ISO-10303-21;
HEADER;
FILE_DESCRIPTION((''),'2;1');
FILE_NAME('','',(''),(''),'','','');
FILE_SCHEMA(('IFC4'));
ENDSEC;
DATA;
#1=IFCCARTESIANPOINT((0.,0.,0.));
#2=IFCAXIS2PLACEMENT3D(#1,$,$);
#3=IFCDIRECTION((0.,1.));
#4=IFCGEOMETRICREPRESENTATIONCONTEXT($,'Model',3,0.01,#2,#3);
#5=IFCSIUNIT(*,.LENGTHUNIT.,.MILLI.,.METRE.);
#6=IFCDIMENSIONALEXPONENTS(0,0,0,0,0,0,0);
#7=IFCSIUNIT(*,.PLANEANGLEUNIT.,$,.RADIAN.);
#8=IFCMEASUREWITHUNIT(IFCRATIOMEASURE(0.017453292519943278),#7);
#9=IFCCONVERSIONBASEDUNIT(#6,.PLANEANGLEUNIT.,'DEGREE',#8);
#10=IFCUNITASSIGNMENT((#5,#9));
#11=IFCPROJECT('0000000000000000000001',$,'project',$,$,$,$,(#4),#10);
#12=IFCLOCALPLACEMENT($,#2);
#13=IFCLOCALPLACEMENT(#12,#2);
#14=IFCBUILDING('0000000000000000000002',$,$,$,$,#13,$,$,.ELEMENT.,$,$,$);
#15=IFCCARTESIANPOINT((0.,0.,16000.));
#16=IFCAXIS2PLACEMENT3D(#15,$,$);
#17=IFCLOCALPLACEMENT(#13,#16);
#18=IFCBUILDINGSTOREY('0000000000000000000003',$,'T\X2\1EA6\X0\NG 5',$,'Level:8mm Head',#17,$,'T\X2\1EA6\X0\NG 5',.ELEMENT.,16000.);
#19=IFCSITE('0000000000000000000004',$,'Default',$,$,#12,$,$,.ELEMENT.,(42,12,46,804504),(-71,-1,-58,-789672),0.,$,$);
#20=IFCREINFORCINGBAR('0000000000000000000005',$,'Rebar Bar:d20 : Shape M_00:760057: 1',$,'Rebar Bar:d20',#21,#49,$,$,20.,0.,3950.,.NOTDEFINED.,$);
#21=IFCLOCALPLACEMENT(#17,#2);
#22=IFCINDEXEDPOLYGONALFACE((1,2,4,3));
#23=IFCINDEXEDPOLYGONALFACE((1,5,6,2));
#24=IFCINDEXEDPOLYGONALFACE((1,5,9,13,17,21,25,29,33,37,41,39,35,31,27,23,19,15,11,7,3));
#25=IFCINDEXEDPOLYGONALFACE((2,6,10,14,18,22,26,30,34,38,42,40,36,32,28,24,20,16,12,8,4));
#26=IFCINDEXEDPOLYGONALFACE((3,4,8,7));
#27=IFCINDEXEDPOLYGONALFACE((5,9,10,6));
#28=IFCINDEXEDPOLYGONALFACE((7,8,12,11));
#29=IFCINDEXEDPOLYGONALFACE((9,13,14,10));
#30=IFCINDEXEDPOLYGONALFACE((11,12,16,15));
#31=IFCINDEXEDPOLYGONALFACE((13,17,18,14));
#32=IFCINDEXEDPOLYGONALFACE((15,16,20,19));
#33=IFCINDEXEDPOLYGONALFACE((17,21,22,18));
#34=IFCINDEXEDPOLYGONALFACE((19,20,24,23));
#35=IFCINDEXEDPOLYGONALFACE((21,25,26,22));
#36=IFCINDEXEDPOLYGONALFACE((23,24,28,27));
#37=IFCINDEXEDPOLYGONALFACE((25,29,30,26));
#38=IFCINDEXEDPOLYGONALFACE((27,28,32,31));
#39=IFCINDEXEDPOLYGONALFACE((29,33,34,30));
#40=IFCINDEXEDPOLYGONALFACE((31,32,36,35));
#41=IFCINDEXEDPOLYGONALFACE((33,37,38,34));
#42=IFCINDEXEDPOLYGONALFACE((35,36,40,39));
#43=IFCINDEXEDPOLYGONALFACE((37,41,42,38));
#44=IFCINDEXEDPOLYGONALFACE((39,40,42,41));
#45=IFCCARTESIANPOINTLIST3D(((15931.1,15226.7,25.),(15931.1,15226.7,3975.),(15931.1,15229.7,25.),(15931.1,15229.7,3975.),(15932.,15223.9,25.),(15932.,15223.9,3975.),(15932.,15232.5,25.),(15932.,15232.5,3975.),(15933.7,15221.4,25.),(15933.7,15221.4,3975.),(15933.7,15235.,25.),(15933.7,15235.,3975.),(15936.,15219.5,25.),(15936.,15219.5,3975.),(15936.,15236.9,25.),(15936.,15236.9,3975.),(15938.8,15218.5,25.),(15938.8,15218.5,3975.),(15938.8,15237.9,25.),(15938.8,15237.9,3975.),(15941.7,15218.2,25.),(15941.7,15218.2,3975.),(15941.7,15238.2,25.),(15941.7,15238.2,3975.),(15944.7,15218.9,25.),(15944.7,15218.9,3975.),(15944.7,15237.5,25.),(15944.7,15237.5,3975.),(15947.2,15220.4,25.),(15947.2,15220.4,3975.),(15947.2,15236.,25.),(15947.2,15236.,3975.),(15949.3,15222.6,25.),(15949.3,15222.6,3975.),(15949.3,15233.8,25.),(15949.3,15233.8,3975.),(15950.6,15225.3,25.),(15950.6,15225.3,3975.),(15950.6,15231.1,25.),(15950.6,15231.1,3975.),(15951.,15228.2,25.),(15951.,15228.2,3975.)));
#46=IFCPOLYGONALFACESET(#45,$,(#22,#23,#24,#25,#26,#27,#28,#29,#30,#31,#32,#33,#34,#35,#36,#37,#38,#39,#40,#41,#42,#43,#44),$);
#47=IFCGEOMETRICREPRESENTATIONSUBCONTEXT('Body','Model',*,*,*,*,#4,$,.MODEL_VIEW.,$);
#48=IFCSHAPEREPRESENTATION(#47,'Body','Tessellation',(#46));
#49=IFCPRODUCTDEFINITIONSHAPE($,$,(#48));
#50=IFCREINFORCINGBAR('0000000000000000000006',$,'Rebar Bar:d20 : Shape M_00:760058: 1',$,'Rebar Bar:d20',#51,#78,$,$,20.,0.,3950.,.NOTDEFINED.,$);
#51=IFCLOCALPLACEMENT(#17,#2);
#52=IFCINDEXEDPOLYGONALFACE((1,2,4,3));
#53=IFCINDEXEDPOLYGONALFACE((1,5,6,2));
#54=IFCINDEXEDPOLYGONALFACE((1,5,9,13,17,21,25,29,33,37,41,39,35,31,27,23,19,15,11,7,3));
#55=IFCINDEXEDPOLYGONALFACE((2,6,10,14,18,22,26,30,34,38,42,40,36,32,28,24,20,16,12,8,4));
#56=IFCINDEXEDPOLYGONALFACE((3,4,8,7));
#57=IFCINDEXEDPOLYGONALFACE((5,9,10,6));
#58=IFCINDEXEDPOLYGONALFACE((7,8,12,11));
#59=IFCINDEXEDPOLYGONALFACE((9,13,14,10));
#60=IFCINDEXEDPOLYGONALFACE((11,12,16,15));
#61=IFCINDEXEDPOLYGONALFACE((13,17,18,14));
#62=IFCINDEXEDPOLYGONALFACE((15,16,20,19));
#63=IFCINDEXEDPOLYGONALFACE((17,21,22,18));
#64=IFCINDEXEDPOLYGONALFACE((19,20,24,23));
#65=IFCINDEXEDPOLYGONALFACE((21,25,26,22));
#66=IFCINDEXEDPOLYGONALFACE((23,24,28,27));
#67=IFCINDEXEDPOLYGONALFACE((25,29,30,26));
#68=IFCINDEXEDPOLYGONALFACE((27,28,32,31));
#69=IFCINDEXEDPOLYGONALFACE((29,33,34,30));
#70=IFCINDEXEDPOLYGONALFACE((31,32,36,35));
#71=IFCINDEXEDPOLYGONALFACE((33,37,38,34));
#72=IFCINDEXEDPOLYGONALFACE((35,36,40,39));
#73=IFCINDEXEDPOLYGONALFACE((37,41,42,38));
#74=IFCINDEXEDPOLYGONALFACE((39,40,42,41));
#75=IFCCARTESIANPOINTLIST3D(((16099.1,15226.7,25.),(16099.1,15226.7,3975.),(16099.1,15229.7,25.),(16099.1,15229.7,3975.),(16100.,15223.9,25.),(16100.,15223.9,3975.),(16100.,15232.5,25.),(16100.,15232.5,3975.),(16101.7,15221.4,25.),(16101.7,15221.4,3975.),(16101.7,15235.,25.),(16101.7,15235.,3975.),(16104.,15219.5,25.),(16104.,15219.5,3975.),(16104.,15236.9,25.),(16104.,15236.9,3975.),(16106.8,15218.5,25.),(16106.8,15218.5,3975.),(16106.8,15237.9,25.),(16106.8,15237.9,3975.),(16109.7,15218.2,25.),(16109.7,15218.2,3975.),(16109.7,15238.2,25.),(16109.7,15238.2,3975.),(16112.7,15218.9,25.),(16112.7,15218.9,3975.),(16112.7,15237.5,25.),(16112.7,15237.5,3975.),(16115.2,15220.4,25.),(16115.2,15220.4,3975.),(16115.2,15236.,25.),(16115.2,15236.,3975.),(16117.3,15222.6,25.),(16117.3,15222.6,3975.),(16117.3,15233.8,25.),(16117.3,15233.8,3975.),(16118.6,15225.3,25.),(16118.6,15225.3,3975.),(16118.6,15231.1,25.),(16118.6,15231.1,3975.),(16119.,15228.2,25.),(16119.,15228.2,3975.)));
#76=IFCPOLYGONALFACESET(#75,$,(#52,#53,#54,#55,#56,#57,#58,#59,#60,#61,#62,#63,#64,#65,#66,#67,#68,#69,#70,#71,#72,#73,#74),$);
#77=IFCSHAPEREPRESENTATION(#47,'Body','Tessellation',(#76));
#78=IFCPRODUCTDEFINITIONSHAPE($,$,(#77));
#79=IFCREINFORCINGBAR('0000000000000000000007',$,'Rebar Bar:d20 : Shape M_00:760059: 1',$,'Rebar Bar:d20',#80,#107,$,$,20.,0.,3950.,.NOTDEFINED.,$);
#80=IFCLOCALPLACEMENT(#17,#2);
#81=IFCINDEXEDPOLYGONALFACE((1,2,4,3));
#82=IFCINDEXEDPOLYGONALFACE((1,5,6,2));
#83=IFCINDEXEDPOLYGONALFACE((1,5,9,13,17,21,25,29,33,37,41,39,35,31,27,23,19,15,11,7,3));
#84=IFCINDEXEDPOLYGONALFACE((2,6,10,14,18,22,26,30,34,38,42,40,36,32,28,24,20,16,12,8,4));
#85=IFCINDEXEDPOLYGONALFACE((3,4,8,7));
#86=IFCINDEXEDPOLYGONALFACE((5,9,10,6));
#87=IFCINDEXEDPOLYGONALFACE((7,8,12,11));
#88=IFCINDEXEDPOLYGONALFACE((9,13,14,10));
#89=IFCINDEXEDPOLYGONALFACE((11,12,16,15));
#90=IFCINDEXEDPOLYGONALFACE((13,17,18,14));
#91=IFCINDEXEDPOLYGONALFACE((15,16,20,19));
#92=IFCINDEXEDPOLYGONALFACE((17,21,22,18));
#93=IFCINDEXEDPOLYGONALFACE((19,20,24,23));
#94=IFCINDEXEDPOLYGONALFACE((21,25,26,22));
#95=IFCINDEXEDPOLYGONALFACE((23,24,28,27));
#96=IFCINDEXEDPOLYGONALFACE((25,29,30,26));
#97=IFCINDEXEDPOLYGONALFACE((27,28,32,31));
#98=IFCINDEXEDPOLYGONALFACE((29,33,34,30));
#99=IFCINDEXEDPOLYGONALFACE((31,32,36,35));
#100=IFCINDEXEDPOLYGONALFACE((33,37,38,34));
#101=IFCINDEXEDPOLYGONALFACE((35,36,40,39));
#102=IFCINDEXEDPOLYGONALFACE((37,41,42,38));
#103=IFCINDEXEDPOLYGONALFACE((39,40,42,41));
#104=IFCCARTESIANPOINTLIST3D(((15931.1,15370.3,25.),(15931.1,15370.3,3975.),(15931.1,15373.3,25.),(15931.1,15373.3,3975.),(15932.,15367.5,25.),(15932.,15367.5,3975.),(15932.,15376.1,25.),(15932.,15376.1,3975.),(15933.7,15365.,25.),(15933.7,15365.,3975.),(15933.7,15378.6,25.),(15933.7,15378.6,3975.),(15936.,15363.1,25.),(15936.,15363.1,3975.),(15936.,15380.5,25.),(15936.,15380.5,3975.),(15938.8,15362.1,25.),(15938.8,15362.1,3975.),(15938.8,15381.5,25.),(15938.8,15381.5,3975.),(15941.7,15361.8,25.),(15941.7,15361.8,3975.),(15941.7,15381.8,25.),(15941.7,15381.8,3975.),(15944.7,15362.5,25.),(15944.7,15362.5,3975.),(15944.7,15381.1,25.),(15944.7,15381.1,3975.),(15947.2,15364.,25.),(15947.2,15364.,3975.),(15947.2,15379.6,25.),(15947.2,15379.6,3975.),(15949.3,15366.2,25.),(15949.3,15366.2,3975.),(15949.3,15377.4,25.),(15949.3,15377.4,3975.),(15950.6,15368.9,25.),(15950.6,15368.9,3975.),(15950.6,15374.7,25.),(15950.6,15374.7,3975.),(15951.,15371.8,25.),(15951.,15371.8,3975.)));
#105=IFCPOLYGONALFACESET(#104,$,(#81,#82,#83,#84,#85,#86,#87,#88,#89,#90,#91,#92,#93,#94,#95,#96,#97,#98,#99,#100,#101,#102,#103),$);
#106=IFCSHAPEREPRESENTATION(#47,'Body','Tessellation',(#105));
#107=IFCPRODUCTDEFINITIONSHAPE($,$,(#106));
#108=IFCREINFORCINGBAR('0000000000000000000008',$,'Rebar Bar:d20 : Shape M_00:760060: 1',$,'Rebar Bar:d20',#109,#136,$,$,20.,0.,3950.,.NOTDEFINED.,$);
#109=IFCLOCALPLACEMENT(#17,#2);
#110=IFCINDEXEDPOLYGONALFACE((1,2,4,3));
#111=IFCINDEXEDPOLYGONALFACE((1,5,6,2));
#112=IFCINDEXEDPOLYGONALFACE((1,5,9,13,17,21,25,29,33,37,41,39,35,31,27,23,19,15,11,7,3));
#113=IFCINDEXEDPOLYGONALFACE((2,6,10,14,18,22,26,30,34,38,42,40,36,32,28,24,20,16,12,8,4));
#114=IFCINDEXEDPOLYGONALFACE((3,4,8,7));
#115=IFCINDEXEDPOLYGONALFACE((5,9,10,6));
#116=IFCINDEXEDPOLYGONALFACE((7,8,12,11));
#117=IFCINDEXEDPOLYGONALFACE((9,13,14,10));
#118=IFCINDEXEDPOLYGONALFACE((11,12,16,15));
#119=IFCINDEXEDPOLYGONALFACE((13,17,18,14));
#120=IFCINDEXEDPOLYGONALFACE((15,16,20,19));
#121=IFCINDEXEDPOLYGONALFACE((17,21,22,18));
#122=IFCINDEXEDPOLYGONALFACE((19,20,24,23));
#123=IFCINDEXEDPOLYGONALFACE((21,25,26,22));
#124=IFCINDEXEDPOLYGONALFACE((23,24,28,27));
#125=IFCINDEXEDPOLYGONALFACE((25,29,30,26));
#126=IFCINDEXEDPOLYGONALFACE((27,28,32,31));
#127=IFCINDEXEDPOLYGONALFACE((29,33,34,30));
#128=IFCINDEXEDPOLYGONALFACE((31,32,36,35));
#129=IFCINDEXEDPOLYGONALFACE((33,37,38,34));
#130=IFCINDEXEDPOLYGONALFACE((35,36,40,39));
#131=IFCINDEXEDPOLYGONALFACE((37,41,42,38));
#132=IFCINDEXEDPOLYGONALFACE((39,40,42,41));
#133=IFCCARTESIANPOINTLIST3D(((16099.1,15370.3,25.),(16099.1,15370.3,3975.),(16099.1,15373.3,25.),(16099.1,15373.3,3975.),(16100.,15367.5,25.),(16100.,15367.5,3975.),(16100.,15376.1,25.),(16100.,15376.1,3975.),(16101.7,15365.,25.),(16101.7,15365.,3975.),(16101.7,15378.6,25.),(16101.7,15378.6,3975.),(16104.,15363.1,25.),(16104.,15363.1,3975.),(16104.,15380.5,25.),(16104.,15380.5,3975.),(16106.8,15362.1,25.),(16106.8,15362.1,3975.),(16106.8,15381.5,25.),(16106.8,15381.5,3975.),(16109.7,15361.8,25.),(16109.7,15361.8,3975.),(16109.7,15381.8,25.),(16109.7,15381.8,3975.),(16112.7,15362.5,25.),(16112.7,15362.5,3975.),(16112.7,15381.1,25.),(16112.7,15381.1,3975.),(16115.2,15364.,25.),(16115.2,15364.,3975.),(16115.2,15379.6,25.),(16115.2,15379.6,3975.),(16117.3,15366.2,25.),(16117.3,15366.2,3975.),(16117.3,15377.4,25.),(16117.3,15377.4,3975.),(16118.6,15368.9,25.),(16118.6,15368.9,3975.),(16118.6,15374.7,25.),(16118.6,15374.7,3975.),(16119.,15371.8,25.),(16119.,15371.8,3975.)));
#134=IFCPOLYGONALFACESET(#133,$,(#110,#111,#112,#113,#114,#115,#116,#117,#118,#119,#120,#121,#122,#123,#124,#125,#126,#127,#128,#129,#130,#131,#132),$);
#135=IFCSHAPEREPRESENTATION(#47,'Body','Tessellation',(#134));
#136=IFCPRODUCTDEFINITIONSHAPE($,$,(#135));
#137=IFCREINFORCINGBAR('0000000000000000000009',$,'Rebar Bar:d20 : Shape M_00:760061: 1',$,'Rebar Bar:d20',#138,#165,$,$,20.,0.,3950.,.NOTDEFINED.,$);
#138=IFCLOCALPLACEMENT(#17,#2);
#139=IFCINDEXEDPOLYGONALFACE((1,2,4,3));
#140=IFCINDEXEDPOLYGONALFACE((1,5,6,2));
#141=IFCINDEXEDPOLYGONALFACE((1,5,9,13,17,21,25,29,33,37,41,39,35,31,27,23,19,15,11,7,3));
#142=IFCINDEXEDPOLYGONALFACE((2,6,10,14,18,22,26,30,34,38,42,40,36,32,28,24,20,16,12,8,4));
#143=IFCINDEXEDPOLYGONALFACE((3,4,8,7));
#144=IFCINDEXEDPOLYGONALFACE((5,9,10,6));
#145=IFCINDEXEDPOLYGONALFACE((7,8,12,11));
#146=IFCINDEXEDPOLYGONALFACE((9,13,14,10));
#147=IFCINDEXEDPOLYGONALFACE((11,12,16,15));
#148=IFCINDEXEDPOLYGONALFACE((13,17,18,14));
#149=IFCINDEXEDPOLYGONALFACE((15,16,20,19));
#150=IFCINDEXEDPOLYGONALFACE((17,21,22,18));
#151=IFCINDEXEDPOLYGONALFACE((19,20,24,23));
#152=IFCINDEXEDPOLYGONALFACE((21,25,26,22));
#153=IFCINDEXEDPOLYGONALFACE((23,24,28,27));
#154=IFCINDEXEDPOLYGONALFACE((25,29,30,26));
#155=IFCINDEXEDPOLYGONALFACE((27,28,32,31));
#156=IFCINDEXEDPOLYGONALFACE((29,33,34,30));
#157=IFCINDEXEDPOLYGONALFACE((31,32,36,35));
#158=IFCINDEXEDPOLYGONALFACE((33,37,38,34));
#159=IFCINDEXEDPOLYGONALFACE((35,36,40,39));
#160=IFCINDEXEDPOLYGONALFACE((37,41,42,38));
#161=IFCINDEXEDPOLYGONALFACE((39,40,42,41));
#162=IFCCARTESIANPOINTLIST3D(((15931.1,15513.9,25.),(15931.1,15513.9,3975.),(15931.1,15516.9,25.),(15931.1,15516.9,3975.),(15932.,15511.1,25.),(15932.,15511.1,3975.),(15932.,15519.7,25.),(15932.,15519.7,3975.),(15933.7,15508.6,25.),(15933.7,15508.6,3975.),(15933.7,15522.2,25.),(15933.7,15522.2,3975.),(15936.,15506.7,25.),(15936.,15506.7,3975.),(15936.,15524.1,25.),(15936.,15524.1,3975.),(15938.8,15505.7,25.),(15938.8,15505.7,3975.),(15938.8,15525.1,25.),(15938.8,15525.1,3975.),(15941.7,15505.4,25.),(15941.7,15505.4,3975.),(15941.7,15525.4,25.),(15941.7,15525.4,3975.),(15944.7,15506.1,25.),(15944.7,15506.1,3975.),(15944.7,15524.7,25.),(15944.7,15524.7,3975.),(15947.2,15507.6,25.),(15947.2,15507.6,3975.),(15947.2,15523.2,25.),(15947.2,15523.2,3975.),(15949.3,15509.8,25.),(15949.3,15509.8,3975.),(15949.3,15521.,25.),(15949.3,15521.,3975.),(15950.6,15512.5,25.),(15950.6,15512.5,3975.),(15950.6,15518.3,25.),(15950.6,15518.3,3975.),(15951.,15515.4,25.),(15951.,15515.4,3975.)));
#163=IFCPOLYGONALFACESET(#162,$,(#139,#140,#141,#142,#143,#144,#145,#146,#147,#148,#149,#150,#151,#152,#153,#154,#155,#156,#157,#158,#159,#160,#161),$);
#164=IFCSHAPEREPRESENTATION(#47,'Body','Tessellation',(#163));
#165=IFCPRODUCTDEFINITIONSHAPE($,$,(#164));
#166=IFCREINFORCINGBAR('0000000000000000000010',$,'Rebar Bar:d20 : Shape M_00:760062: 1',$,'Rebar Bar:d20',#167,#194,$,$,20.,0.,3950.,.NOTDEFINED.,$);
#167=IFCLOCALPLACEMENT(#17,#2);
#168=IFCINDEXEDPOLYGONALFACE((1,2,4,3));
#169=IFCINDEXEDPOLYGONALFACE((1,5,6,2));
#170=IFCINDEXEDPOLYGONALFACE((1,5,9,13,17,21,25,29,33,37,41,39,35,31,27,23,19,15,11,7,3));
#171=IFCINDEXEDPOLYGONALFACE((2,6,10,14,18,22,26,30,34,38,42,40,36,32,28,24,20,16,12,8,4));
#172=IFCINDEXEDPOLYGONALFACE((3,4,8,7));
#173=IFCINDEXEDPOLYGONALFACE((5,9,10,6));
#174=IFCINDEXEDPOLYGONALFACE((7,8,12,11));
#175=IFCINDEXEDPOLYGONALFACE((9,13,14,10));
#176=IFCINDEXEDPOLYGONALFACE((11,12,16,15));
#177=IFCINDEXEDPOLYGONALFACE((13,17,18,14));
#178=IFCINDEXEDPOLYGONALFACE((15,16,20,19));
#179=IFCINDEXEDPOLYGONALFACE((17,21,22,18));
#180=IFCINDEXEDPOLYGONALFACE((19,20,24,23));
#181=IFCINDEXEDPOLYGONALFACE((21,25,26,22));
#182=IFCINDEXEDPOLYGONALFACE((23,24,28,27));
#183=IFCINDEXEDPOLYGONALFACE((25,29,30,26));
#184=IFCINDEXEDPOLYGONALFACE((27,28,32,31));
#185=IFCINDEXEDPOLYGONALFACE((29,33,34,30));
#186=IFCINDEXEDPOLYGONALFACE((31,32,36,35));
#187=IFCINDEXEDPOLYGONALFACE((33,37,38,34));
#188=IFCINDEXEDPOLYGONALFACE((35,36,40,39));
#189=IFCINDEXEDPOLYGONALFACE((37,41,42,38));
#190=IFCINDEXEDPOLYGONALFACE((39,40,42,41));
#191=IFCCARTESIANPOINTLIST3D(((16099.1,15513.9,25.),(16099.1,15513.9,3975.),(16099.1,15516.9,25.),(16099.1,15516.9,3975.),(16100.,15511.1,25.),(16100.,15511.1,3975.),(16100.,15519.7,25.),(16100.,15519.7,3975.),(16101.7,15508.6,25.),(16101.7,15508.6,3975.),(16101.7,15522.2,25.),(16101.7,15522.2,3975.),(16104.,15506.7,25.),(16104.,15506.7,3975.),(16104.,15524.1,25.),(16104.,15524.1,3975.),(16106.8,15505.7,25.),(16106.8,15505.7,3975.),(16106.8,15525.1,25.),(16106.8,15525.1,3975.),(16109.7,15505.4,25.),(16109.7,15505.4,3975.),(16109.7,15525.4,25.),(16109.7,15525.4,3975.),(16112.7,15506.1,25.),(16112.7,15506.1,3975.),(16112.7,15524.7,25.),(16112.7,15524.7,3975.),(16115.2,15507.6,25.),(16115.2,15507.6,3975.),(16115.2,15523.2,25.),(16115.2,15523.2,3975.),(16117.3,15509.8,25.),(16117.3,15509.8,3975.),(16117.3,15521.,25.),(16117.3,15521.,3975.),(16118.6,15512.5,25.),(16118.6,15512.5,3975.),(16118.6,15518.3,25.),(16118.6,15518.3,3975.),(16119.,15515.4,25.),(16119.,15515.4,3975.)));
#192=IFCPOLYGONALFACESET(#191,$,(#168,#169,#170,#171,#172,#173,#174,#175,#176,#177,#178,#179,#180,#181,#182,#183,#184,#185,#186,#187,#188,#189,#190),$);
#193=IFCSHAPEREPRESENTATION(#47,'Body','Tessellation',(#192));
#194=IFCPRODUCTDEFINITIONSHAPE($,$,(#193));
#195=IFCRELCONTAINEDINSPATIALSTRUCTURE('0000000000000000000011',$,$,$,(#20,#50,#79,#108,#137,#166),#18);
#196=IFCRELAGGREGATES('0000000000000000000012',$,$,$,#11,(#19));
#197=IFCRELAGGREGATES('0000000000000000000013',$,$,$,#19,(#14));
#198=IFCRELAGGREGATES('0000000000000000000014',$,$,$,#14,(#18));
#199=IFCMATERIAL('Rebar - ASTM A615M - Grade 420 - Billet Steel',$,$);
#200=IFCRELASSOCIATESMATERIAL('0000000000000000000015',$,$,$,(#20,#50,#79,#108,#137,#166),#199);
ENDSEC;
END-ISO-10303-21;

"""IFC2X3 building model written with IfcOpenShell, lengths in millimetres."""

from ifc_helpers import new_model, entity, si_unit, converted_unit, direction, frame, origin, place, context, subcontext, project, spatial, material, element, save


model = new_model("IFC2X3")

# Units and contexts
model_context = context("Model", 3, precision=0.01, world=origin(), true_north=direction((0.0, 1.0)))
body_context = subcontext(model_context, "Body", "Model", "MODEL_VIEW")
ifc_project = project(units=[si_unit("LENGTHUNIT", "METRE", prefix="MILLI"), converted_unit("PLANEANGLEUNIT", "DEGREE", entity("IfcRatioMeasure", 0.017453292519943278), si_unit("PLANEANGLEUNIT", "RADIAN"), dimensions=[0, 0, 0, 0, 0, 0, 0])], contexts=[model_context])

# Site, building, storey
site_placement = place(None, origin())
site = spatial("IfcSite", under=ifc_project, at=site_placement, Name="Default", CompositionType="ELEMENT", RefLatitude=(42, 12, 46, 804504), RefLongitude=(-71, -1, -58, -789672), RefElevation=0.0)
building_placement = place(site_placement, origin())
building = spatial("IfcBuilding", under=site, at=building_placement, CompositionType="ELEMENT")
storey_placement = place(building_placement, frame((0.0, 0.0, 16000.0)))
storey = spatial("IfcBuildingStorey", under=building, at=storey_placement, Name="TẦNG 5", ObjectType="Level:8mm Head", LongName="TẦNG 5", CompositionType="ELEMENT", Elevation=16000.0)

# Reinforcing bars
ifc_material = material(Name="Rebar - ASTM A615M - Grade 420 - Billet Steel")
reinforcing_bar_1_placement = place(storey_placement, origin())
element("IfcReinforcingBar", 1, at=reinforcing_bar_1_placement, inside=storey, material=ifc_material, Name="Rebar Bar:d20 : Shape M_00:760057: 1", ObjectType="Rebar Bar:d20", BarLength=3950.0, BarRole="NOTDEFINED", CrossSectionArea=0.0, NominalDiameter=20.0, context=body_context, shape_type="AdvancedSweptSolid", body=[
    entity("IfcSweptDiskSolid", entity("IfcCompositeCurve", [entity("IfcCompositeCurveSegment", "CONTINUOUS", True, entity("IfcPolyline", [entity("IfcCartesianPoint", [15941.0, 15228.2, 25.0]), entity("IfcCartesianPoint", [15941.0, 15228.2, 3975.0])]))], False), 10.0, None, 0.0, 1.0),
])
reinforcing_bar_2_placement = place(storey_placement, origin())
element("IfcReinforcingBar", 2, at=reinforcing_bar_2_placement, inside=storey, material=ifc_material, Name="Rebar Bar:d20 : Shape M_00:760058: 1", ObjectType="Rebar Bar:d20", BarLength=3950.0, BarRole="NOTDEFINED", CrossSectionArea=0.0, NominalDiameter=20.0, context=body_context, shape_type="AdvancedSweptSolid", body=[
    entity("IfcSweptDiskSolid", entity("IfcCompositeCurve", [entity("IfcCompositeCurveSegment", "CONTINUOUS", True, entity("IfcPolyline", [entity("IfcCartesianPoint", [16109.0, 15228.2, 25.0]), entity("IfcCartesianPoint", [16109.0, 15228.2, 3975.0])]))], False), 10.0, None, 0.0, 1.0),
])
reinforcing_bar_3_placement = place(storey_placement, origin())
element("IfcReinforcingBar", 3, at=reinforcing_bar_3_placement, inside=storey, material=ifc_material, Name="Rebar Bar:d20 : Shape M_00:760059: 1", ObjectType="Rebar Bar:d20", BarLength=3950.0, BarRole="NOTDEFINED", CrossSectionArea=0.0, NominalDiameter=20.0, context=body_context, shape_type="AdvancedSweptSolid", body=[
    entity("IfcSweptDiskSolid", entity("IfcCompositeCurve", [entity("IfcCompositeCurveSegment", "CONTINUOUS", True, entity("IfcPolyline", [entity("IfcCartesianPoint", [15941.0, 15371.8, 25.0]), entity("IfcCartesianPoint", [15941.0, 15371.8, 3975.0])]))], False), 10.0, None, 0.0, 1.0),
])
reinforcing_bar_4_placement = place(storey_placement, origin())
element("IfcReinforcingBar", 4, at=reinforcing_bar_4_placement, inside=storey, material=ifc_material, Name="Rebar Bar:d20 : Shape M_00:760060: 1", ObjectType="Rebar Bar:d20", BarLength=3950.0, BarRole="NOTDEFINED", CrossSectionArea=0.0, NominalDiameter=20.0, context=body_context, shape_type="AdvancedSweptSolid", body=[
    entity("IfcSweptDiskSolid", entity("IfcCompositeCurve", [entity("IfcCompositeCurveSegment", "CONTINUOUS", True, entity("IfcPolyline", [entity("IfcCartesianPoint", [16109.0, 15371.8, 25.0]), entity("IfcCartesianPoint", [16109.0, 15371.8, 3975.0])]))], False), 10.0, None, 0.0, 1.0),
])
reinforcing_bar_5_placement = place(storey_placement, origin())
element("IfcReinforcingBar", 5, at=reinforcing_bar_5_placement, inside=storey, material=ifc_material, Name="Rebar Bar:d20 : Shape M_00:760061: 1", ObjectType="Rebar Bar:d20", BarLength=3950.0, BarRole="NOTDEFINED", CrossSectionArea=0.0, NominalDiameter=20.0, context=body_context, shape_type="AdvancedSweptSolid", body=[
    entity("IfcSweptDiskSolid", entity("IfcCompositeCurve", [entity("IfcCompositeCurveSegment", "CONTINUOUS", True, entity("IfcPolyline", [entity("IfcCartesianPoint", [15941.0, 15515.4, 25.0]), entity("IfcCartesianPoint", [15941.0, 15515.4, 3975.0])]))], False), 10.0, None, 0.0, 1.0),
])
reinforcing_bar_6_placement = place(storey_placement, origin())
element("IfcReinforcingBar", 6, at=reinforcing_bar_6_placement, inside=storey, material=ifc_material, Name="Rebar Bar:d20 : Shape M_00:760062: 1", ObjectType="Rebar Bar:d20", BarLength=3950.0, BarRole="NOTDEFINED", CrossSectionArea=0.0, NominalDiameter=20.0, context=body_context, shape_type="AdvancedSweptSolid", body=[
    entity("IfcSweptDiskSolid", entity("IfcCompositeCurve", [entity("IfcCompositeCurveSegment", "CONTINUOUS", True, entity("IfcPolyline", [entity("IfcCartesianPoint", [16109.0, 15515.4, 25.0]), entity("IfcCartesianPoint", [16109.0, 15515.4, 3975.0])]))], False), 10.0, None, 0.0, 1.0),
])

save(model, "model.ifc")
